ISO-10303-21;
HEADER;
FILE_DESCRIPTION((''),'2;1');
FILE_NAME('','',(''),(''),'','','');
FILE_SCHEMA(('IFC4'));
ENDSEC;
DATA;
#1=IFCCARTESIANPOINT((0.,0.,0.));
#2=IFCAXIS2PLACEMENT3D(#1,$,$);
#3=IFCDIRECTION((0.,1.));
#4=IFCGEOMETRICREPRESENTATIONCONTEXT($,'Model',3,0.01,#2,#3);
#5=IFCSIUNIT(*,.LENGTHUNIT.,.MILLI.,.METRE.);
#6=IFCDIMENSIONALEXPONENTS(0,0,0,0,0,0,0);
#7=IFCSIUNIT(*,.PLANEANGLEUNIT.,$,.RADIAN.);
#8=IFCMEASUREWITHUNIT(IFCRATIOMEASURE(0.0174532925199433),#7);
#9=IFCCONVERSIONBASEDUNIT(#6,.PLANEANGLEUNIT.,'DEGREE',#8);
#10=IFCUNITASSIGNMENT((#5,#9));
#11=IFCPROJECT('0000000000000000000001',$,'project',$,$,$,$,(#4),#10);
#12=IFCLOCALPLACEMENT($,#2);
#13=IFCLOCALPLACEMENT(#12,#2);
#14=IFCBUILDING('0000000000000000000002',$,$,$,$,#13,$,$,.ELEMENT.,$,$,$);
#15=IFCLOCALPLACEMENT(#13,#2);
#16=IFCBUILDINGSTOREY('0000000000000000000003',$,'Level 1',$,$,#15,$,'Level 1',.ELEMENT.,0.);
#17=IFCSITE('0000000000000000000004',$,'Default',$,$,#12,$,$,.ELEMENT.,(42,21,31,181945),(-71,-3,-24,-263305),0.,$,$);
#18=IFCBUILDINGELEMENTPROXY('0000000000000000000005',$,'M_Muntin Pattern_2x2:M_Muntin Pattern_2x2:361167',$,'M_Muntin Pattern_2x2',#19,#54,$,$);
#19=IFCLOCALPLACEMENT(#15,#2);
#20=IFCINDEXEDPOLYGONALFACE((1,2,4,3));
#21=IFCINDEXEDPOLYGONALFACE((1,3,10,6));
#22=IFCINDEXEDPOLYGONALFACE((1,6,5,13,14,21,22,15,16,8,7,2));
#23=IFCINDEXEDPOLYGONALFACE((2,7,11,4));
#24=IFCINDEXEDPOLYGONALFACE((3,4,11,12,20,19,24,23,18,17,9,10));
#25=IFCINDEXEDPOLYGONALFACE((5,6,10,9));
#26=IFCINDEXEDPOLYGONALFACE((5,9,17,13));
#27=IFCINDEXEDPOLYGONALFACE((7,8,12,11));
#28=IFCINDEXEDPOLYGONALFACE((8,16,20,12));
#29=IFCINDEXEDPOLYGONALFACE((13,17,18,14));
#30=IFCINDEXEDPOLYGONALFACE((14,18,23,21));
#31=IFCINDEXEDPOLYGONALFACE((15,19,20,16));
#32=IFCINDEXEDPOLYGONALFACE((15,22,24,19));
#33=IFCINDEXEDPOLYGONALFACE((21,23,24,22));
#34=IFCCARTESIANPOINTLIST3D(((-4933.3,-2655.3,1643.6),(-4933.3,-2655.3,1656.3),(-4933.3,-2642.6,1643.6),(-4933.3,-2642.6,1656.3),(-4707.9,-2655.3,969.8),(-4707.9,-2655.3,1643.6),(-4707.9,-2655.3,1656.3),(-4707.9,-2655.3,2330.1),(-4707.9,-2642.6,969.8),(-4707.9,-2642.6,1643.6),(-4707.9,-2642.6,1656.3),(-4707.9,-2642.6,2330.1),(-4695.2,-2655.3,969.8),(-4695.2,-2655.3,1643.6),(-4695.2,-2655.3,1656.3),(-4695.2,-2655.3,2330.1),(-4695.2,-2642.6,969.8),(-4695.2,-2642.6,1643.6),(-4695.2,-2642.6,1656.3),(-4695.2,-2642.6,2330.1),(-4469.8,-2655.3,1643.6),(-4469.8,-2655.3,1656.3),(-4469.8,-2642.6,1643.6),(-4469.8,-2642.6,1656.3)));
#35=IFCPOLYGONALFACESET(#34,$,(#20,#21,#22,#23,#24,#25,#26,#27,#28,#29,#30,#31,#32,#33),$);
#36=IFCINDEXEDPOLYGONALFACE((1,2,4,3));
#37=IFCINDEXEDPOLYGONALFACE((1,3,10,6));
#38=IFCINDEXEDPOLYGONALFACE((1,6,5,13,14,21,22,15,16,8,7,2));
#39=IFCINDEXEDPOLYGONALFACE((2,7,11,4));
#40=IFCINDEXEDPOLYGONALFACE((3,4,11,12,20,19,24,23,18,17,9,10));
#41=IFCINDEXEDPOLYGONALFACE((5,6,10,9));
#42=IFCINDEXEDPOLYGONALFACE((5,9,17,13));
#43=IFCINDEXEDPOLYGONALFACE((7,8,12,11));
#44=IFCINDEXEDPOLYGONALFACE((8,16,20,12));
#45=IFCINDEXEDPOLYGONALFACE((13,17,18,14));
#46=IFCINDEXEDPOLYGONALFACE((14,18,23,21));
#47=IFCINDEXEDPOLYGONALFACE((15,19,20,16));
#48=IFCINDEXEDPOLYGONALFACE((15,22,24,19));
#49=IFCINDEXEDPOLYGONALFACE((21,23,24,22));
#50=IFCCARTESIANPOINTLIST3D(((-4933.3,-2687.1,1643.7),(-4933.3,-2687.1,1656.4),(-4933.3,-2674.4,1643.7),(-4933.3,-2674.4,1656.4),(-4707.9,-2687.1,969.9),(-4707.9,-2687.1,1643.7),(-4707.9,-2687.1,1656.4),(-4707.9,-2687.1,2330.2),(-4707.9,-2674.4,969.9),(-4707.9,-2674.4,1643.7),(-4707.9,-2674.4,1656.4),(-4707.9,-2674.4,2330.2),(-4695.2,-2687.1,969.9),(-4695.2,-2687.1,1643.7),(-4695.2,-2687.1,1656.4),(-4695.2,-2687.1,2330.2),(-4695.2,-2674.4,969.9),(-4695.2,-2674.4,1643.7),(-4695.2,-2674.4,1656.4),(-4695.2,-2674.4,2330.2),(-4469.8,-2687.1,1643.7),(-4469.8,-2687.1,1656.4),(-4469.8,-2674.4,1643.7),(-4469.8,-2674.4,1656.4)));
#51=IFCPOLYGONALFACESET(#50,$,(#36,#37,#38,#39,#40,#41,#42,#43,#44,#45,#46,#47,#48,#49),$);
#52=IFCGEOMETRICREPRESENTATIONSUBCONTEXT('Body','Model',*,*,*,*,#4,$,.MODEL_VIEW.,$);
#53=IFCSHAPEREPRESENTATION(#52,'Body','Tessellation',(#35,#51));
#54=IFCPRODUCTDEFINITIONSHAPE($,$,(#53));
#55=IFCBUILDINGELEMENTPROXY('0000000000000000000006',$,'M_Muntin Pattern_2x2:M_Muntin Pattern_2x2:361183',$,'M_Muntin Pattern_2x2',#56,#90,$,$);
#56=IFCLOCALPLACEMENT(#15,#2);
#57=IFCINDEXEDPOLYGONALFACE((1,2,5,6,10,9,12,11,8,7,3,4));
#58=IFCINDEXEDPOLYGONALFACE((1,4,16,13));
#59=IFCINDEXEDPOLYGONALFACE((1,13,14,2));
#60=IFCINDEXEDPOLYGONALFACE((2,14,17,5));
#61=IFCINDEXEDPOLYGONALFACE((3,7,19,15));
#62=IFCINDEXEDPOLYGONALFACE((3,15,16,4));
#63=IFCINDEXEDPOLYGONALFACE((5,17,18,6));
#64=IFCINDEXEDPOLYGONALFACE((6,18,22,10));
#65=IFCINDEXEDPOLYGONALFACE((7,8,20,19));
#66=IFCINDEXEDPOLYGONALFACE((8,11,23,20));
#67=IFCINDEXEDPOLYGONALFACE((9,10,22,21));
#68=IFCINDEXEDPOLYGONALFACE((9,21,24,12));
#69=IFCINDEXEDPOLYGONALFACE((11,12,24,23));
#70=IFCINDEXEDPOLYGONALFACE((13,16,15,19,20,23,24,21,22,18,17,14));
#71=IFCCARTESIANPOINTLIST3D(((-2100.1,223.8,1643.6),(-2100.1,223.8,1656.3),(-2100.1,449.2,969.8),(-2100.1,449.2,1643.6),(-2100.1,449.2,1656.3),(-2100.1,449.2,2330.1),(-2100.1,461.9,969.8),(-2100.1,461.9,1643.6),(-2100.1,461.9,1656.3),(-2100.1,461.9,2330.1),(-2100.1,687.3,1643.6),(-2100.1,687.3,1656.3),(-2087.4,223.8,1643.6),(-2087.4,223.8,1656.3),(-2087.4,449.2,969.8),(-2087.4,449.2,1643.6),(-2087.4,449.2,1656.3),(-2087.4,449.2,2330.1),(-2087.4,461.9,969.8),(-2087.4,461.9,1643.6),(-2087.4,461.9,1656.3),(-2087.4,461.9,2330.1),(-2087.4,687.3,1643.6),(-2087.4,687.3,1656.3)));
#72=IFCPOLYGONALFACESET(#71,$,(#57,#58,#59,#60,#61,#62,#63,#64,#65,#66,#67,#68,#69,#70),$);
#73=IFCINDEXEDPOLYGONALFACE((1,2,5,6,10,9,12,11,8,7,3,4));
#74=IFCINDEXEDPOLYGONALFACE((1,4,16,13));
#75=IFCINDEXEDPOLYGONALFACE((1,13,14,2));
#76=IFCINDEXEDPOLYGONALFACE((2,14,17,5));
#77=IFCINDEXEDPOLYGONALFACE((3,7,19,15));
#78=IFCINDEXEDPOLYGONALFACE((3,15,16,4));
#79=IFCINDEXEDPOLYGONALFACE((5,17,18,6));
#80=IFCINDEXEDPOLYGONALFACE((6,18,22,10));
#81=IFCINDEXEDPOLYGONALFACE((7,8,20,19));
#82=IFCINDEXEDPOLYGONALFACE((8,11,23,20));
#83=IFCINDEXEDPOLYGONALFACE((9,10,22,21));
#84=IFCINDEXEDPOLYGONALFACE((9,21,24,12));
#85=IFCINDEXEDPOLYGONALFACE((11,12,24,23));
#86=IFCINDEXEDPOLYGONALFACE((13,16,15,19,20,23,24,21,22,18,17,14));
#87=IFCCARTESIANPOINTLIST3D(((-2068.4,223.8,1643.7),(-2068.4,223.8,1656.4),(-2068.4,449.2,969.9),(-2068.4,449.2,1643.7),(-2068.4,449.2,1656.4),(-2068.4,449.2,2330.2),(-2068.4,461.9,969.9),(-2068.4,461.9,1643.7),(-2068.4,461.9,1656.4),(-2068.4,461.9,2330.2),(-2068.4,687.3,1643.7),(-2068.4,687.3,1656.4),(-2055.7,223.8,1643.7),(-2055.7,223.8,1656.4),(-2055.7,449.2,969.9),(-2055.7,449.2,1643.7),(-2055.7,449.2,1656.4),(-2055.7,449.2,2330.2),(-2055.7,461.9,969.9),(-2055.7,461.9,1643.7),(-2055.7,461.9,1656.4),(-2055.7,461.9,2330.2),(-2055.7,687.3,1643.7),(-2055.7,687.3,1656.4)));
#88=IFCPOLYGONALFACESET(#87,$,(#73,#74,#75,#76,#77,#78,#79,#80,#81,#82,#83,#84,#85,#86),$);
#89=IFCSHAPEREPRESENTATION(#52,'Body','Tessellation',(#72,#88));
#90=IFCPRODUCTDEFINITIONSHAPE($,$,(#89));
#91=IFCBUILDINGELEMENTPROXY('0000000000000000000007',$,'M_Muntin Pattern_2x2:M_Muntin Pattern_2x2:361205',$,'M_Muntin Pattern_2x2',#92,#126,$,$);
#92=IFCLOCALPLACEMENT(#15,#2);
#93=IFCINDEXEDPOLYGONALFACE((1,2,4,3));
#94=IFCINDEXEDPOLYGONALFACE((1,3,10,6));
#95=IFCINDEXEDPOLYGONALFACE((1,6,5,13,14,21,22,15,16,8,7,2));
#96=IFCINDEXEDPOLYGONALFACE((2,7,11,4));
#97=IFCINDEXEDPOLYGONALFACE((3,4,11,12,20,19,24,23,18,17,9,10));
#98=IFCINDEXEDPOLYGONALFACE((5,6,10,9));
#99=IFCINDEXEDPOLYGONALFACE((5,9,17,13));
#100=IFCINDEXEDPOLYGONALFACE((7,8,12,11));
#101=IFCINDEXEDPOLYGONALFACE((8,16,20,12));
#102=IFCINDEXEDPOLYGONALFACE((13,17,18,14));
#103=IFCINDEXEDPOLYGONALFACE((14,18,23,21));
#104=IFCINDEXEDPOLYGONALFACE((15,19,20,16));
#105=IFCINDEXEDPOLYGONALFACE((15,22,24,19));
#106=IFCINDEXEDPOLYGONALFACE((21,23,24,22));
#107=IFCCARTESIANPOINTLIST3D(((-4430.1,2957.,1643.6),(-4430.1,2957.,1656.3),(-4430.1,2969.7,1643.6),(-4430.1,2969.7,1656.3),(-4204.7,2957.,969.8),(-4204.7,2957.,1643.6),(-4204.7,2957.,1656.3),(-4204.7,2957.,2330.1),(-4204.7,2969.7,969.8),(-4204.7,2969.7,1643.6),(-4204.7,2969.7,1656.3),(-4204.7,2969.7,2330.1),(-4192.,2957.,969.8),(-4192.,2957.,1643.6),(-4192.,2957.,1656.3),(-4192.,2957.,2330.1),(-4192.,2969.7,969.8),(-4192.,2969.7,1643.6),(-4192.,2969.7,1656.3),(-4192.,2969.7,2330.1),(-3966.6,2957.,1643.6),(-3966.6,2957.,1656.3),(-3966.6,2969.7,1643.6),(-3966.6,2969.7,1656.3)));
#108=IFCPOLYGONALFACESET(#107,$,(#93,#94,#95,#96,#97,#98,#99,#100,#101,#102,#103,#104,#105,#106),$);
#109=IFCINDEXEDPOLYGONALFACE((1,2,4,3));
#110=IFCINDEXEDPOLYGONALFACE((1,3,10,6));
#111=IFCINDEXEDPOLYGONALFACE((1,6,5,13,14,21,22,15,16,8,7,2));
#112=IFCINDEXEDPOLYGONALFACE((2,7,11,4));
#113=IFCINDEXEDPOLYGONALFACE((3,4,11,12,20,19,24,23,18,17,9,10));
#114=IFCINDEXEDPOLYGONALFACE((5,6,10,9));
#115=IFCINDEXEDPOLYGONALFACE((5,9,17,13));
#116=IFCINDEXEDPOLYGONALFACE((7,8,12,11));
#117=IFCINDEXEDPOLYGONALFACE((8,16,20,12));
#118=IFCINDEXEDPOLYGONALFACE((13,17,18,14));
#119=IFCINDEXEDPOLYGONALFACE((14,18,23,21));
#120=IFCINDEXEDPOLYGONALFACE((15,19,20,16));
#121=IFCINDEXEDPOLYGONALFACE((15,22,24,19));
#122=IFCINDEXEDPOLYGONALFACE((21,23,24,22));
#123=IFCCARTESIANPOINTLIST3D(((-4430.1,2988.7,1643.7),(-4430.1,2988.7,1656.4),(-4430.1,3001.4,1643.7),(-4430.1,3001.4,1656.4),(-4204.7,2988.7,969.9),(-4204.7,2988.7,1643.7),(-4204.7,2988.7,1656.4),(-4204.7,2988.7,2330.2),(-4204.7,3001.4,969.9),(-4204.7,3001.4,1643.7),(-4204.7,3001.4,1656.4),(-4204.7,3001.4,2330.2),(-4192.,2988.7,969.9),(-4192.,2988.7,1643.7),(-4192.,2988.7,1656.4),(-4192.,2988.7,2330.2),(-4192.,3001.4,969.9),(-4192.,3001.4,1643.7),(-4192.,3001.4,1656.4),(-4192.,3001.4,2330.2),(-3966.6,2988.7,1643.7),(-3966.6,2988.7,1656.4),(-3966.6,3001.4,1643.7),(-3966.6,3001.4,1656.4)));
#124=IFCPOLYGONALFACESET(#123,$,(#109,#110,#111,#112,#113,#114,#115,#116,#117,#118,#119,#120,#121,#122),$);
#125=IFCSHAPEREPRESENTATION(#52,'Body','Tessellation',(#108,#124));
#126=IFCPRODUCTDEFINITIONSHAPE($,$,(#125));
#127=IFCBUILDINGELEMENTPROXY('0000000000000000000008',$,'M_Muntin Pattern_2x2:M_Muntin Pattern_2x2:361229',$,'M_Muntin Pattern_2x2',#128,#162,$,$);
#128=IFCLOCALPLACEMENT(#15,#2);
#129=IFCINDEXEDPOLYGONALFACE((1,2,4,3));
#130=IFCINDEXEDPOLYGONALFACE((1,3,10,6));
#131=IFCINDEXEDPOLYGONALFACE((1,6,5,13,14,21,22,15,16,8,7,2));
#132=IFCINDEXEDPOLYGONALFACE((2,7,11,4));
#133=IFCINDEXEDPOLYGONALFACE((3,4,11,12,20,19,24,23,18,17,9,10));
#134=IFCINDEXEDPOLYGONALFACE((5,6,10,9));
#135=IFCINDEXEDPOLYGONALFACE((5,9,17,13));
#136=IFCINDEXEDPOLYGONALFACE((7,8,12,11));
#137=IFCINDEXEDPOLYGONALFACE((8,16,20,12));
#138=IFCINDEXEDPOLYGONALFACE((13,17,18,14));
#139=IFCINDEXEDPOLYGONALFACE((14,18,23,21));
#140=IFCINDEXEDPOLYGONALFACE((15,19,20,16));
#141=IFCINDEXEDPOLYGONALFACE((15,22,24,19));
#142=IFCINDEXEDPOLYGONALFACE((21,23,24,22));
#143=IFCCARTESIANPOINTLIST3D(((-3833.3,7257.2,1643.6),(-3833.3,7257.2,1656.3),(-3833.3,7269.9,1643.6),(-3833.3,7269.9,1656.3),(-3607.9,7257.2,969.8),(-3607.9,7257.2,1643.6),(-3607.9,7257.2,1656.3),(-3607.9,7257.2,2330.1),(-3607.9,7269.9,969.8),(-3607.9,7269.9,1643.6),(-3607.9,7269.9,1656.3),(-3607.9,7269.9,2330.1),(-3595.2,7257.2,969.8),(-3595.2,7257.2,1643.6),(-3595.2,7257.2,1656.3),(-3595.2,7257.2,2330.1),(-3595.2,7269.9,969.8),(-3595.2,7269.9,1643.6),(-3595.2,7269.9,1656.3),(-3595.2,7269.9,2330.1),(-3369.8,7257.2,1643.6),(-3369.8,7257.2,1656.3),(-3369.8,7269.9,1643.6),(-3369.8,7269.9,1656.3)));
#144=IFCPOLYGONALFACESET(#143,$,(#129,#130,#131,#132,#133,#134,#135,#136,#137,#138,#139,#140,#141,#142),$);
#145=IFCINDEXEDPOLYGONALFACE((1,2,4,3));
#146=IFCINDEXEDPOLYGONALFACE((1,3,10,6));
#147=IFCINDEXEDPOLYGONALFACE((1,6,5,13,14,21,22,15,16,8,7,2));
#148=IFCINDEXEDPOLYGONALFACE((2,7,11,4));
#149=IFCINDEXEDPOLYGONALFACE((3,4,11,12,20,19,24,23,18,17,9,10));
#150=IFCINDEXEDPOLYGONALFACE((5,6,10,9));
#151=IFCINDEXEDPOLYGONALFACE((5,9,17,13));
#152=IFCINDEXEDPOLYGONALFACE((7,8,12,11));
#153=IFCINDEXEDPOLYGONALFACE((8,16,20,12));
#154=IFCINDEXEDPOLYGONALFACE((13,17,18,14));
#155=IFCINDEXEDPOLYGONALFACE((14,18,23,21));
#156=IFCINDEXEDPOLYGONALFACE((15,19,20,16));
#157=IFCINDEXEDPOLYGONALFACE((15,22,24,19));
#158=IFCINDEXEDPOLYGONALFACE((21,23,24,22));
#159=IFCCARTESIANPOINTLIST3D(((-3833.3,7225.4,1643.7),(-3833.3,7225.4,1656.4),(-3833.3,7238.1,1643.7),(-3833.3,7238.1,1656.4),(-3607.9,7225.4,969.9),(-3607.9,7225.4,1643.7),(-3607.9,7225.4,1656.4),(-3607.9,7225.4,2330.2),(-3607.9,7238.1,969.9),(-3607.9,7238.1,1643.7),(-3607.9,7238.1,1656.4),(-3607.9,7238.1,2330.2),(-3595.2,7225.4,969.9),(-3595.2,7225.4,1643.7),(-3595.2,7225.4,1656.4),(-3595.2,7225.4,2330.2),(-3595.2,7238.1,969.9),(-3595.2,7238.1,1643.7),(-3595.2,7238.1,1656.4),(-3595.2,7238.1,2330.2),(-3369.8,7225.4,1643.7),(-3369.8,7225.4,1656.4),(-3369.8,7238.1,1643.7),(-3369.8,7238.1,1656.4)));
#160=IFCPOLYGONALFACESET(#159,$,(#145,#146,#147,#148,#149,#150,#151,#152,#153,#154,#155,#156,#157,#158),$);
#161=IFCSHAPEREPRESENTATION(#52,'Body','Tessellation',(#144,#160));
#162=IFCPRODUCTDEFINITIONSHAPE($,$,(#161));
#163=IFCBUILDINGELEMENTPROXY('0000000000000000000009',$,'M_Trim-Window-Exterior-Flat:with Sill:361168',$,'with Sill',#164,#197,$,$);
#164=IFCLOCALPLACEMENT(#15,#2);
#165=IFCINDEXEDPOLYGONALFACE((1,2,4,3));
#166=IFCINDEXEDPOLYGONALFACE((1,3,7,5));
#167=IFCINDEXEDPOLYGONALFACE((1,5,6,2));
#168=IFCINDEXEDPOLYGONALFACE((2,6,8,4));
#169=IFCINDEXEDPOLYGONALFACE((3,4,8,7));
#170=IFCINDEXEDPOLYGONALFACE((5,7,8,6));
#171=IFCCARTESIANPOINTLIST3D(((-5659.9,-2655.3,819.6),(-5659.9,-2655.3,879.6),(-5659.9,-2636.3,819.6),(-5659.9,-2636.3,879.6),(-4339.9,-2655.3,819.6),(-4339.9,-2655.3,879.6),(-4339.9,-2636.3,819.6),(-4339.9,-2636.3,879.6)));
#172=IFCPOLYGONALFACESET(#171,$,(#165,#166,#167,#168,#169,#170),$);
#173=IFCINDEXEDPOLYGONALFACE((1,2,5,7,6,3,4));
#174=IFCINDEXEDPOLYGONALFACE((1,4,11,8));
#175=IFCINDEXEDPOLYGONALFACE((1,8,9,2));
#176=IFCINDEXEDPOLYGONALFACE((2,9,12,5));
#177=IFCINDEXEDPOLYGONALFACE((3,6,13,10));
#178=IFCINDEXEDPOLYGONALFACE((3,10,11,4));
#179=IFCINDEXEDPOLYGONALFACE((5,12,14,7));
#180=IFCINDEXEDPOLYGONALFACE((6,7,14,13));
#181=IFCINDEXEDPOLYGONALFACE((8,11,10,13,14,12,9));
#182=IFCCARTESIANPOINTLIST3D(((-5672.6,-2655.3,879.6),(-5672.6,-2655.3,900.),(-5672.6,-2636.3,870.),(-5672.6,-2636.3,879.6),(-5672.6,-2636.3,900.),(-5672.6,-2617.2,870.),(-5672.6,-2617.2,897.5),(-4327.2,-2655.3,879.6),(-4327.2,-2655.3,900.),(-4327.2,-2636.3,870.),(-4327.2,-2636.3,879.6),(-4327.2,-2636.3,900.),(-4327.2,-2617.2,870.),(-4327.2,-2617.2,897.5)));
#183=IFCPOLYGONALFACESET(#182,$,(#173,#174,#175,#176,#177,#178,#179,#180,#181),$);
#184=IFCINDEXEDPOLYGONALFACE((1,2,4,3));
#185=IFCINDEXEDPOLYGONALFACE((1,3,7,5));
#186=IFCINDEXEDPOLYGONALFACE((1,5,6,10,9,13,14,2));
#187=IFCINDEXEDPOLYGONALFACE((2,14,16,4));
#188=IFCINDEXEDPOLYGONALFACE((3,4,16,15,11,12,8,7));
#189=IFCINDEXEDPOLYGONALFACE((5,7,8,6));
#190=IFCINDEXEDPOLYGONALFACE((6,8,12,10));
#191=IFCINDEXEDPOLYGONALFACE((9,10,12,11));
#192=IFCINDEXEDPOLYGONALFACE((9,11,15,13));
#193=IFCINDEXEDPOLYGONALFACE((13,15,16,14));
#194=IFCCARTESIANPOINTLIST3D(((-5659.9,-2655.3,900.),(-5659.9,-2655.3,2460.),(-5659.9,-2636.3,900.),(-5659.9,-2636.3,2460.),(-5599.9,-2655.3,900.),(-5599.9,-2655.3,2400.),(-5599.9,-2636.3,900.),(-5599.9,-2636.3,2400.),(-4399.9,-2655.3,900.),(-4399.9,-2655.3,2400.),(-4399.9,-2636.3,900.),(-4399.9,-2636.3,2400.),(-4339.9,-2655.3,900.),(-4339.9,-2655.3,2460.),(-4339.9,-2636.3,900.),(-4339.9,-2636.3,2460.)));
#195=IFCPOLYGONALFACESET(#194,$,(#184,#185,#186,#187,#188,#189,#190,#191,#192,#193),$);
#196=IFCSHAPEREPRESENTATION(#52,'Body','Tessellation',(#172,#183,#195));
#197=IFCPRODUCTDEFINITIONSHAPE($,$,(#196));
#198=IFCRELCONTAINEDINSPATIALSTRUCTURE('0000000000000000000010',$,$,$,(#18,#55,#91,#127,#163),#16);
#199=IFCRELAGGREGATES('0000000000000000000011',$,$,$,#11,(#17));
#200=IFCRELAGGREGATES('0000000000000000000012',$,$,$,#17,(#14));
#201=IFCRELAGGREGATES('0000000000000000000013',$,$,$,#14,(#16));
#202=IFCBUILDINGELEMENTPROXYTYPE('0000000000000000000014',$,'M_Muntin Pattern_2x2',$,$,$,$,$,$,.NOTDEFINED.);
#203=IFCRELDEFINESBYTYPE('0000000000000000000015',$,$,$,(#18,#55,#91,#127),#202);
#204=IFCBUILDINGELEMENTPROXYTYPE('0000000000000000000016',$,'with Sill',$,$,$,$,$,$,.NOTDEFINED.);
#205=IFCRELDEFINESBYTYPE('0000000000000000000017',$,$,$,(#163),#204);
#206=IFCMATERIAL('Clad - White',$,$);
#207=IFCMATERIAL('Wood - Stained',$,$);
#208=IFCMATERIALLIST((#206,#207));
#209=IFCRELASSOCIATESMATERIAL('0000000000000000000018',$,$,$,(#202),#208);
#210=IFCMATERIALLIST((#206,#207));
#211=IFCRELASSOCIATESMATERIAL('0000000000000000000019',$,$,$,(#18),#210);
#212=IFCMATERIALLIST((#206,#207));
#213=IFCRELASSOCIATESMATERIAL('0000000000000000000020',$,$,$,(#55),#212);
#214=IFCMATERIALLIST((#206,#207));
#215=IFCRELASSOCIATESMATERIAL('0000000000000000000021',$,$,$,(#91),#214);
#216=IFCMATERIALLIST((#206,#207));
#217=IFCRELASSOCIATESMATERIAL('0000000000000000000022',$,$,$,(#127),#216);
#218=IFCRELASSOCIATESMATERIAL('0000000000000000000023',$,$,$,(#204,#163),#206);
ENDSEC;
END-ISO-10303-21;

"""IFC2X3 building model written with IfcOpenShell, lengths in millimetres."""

from ifc_helpers import new_model, entity, si_unit, converted_unit, direction, frame, frame_2d, origin, place, context, subcontext, project, spatial, polyline, rectangle, outline, extrude, source, transform, mapped, material, material_list, type_object, type_shapes, element, save


model = new_model("IFC2X3")

# Units and contexts
model_context = context("Model", 3, precision=0.01, world=origin(), true_north=direction((0.0, 1.0)))
body_context = subcontext(model_context, "Body", "Model", "MODEL_VIEW")
ifc_project = project(units=[si_unit("LENGTHUNIT", "METRE", prefix="MILLI"), converted_unit("PLANEANGLEUNIT", "DEGREE", entity("IfcRatioMeasure", 0.0174532925199433), si_unit("PLANEANGLEUNIT", "RADIAN"), dimensions=[0, 0, 0, 0, 0, 0, 0])], contexts=[model_context])

# Site, building, storey
site_placement = place(None, origin())
site = spatial("IfcSite", under=ifc_project, at=site_placement, Name="Default", CompositionType="ELEMENT", RefLatitude=(42, 21, 31, 181945), RefLongitude=(-71, -3, -24, -263305), RefElevation=0.0)
building_placement = place(site_placement, origin())
building = spatial("IfcBuilding", under=site, at=building_placement, CompositionType="ELEMENT")
storey_placement = place(building_placement, origin())
storey = spatial("IfcBuildingStorey", under=building, at=storey_placement, Name="Level 1", LongName="Level 1", CompositionType="ELEMENT", Elevation=0.0)

# Building element proxies
ifc_material_1 = material(Name="Clad - White")
ifc_material_2 = material(Name="Wood - Stained")
ifc_material_list_1 = material_list([ifc_material_1, ifc_material_2])
ifc_material_list_2 = material_list([ifc_material_1, ifc_material_2])
building_element_proxy_type_1 = type_object("IfcBuildingElementProxyType", Name="M_Muntin Pattern_2x2", PredefinedType="NOTDEFINED", material=ifc_material_list_2)
shared_shape_1 = source(origin(), body_context, "Body", "SweptSolid", [
    extrude(outline(polyline([(6.4, -6.4), (680.1, -6.4), (680.1, 6.3), (6.4, 6.3), (6.4, 231.7), (-6.3, 231.7), (-6.3, 6.3), (-680.2, 6.3), (-680.2, -6.4), (-6.3, -6.4), (-6.3, -231.7), (6.4, -231.7), (6.4, -6.4)])), frame((0.0, -22.2, 680.1), z_axis=(0.0, 1.0, 0.0), x_axis=(0.0, 0.0, 1.0)), (0.0, 0.0, 1.0), 12.7),
    extrude(outline(polyline([(6.4, -6.4), (680.1, -6.4), (680.1, 6.3), (6.4, 6.3), (6.4, 231.7), (-6.3, 231.7), (-6.3, 6.3), (-680.2, 6.3), (-680.2, -6.4), (-6.3, -6.4), (-6.3, -231.7), (6.4, -231.7), (6.4, -6.4)])), frame((0.0, 9.5, 680.2), z_axis=(0.0, 1.0, 0.0), x_axis=(0.0, 0.0, 1.0)), (0.0, 0.0, 1.0), 12.7),
])
type_shapes(building_element_proxy_type_1, [shared_shape_1])
proxy_1_placement = place(storey_placement, frame((-4701.5, -2664.9, 969.9), z_axis=(0.0, 0.0, 1.0), x_axis=(-1.0, 0.0, 0.0)))
element("IfcBuildingElementProxy", 1, at=proxy_1_placement, inside=storey, type_object=building_element_proxy_type_1, material=ifc_material_list_1, Name="M_Muntin Pattern_2x2:M_Muntin Pattern_2x2:361167", ObjectType="M_Muntin Pattern_2x2", context=body_context, shape_type="MappedRepresentation", body=[
    mapped(shared_shape_1, transform((0.0, 0.0, 0.0), scale=1.0)),
])
ifc_material_list_3 = material_list([ifc_material_1, ifc_material_2])
proxy_2_placement = place(storey_placement, frame((-2077.9, 455.6, 969.9), z_axis=(0.0, 0.0, 1.0), x_axis=(0.0, -1.0, 0.0)))
element("IfcBuildingElementProxy", 2, at=proxy_2_placement, inside=storey, type_object=building_element_proxy_type_1, material=ifc_material_list_3, Name="M_Muntin Pattern_2x2:M_Muntin Pattern_2x2:361183", ObjectType="M_Muntin Pattern_2x2", context=body_context, shape_type="MappedRepresentation", body=[
    mapped(shared_shape_1, transform((0.0, 0.0, 0.0), scale=1.0)),
])
ifc_material_list_4 = material_list([ifc_material_1, ifc_material_2])
proxy_3_placement = place(storey_placement, frame((-4198.4, 2979.2, 969.9)))
element("IfcBuildingElementProxy", 3, at=proxy_3_placement, inside=storey, type_object=building_element_proxy_type_1, material=ifc_material_list_4, Name="M_Muntin Pattern_2x2:M_Muntin Pattern_2x2:361205", ObjectType="M_Muntin Pattern_2x2", context=body_context, shape_type="MappedRepresentation", body=[
    mapped(shared_shape_1, transform((0.0, 0.0, 0.0), scale=1.0)),
])
ifc_material_list_5 = material_list([ifc_material_1, ifc_material_2])
proxy_4_placement = place(storey_placement, frame((-3601.5, 7247.6, 969.9), z_axis=(0.0, 0.0, 1.0), x_axis=(-1.0, 0.0, 0.0)))
element("IfcBuildingElementProxy", 4, at=proxy_4_placement, inside=storey, type_object=building_element_proxy_type_1, material=ifc_material_list_5, Name="M_Muntin Pattern_2x2:M_Muntin Pattern_2x2:361229", ObjectType="M_Muntin Pattern_2x2", context=body_context, shape_type="MappedRepresentation", body=[
    mapped(shared_shape_1, transform((0.0, 0.0, 0.0), scale=1.0)),
])
building_element_proxy_type_2 = type_object("IfcBuildingElementProxyType", Name="with Sill", PredefinedType="NOTDEFINED", material=ifc_material_1)
shared_shape_2 = source(origin(), body_context, "Body", "SweptSolid", [
    extrude(rectangle(XDim=1320.0, YDim=60.0, at=frame_2d((0.0, 0.0), x_axis=(1.0, 0.0))), frame((0.0, -1550.4, 0.0), z_axis=(0.0, 0.0, 1.0), x_axis=(-1.0, 0.0, 0.0)), (0.0, 0.0, 1.0), 19.1),
    extrude(outline(polyline([(-19.0, -15.2), (0.0, -15.2), (0.0, -5.7), (19.0, -5.7), (19.0, 14.8), (0.0, 14.8), (-19.0, 12.3), (-19.0, -15.2)])), frame((-672.7, -1514.8, 19.0), z_axis=(1.0, 0.0, 0.0), x_axis=(0.0, 0.0, -1.0)), (0.0, 0.0, 1.0), 1345.4),
    extrude(outline(polyline([(-795.0, -660.0), (765.0, -660.0), (765.0, -600.0), (-735.0, -600.0), (-735.0, 600.0), (765.0, 600.0), (765.0, 660.0), (-795.0, 660.0), (-795.0, -660.0)])), frame((0.0, -735.0, 0.0), z_axis=(0.0, 0.0, 1.0), x_axis=(0.0, -1.0, 0.0)), (0.0, 0.0, 1.0), 19.1),
])
type_shapes(building_element_proxy_type_2, [shared_shape_2])
for number, where, z_axis, x_axis, name in (
    (5, (-4999.9, -2655.3, 2400.0), (0.0, 1.0, 0.0), (-1.0, 0.0, 0.0), "M_Trim-Window-Exterior-Flat:with Sill:361168"),
):
    element("IfcBuildingElementProxy", number, at=place(storey_placement, frame(where, z_axis=z_axis, x_axis=x_axis)), inside=storey, type_object=building_element_proxy_type_2, material=ifc_material_1, Name=name, ObjectType="with Sill", context=body_context, shape_type="MappedRepresentation", body=[
        mapped(shared_shape_2, transform((0.0, 0.0, 0.0), scale=1.0)),
    ])

save(model, "model.ifc")
